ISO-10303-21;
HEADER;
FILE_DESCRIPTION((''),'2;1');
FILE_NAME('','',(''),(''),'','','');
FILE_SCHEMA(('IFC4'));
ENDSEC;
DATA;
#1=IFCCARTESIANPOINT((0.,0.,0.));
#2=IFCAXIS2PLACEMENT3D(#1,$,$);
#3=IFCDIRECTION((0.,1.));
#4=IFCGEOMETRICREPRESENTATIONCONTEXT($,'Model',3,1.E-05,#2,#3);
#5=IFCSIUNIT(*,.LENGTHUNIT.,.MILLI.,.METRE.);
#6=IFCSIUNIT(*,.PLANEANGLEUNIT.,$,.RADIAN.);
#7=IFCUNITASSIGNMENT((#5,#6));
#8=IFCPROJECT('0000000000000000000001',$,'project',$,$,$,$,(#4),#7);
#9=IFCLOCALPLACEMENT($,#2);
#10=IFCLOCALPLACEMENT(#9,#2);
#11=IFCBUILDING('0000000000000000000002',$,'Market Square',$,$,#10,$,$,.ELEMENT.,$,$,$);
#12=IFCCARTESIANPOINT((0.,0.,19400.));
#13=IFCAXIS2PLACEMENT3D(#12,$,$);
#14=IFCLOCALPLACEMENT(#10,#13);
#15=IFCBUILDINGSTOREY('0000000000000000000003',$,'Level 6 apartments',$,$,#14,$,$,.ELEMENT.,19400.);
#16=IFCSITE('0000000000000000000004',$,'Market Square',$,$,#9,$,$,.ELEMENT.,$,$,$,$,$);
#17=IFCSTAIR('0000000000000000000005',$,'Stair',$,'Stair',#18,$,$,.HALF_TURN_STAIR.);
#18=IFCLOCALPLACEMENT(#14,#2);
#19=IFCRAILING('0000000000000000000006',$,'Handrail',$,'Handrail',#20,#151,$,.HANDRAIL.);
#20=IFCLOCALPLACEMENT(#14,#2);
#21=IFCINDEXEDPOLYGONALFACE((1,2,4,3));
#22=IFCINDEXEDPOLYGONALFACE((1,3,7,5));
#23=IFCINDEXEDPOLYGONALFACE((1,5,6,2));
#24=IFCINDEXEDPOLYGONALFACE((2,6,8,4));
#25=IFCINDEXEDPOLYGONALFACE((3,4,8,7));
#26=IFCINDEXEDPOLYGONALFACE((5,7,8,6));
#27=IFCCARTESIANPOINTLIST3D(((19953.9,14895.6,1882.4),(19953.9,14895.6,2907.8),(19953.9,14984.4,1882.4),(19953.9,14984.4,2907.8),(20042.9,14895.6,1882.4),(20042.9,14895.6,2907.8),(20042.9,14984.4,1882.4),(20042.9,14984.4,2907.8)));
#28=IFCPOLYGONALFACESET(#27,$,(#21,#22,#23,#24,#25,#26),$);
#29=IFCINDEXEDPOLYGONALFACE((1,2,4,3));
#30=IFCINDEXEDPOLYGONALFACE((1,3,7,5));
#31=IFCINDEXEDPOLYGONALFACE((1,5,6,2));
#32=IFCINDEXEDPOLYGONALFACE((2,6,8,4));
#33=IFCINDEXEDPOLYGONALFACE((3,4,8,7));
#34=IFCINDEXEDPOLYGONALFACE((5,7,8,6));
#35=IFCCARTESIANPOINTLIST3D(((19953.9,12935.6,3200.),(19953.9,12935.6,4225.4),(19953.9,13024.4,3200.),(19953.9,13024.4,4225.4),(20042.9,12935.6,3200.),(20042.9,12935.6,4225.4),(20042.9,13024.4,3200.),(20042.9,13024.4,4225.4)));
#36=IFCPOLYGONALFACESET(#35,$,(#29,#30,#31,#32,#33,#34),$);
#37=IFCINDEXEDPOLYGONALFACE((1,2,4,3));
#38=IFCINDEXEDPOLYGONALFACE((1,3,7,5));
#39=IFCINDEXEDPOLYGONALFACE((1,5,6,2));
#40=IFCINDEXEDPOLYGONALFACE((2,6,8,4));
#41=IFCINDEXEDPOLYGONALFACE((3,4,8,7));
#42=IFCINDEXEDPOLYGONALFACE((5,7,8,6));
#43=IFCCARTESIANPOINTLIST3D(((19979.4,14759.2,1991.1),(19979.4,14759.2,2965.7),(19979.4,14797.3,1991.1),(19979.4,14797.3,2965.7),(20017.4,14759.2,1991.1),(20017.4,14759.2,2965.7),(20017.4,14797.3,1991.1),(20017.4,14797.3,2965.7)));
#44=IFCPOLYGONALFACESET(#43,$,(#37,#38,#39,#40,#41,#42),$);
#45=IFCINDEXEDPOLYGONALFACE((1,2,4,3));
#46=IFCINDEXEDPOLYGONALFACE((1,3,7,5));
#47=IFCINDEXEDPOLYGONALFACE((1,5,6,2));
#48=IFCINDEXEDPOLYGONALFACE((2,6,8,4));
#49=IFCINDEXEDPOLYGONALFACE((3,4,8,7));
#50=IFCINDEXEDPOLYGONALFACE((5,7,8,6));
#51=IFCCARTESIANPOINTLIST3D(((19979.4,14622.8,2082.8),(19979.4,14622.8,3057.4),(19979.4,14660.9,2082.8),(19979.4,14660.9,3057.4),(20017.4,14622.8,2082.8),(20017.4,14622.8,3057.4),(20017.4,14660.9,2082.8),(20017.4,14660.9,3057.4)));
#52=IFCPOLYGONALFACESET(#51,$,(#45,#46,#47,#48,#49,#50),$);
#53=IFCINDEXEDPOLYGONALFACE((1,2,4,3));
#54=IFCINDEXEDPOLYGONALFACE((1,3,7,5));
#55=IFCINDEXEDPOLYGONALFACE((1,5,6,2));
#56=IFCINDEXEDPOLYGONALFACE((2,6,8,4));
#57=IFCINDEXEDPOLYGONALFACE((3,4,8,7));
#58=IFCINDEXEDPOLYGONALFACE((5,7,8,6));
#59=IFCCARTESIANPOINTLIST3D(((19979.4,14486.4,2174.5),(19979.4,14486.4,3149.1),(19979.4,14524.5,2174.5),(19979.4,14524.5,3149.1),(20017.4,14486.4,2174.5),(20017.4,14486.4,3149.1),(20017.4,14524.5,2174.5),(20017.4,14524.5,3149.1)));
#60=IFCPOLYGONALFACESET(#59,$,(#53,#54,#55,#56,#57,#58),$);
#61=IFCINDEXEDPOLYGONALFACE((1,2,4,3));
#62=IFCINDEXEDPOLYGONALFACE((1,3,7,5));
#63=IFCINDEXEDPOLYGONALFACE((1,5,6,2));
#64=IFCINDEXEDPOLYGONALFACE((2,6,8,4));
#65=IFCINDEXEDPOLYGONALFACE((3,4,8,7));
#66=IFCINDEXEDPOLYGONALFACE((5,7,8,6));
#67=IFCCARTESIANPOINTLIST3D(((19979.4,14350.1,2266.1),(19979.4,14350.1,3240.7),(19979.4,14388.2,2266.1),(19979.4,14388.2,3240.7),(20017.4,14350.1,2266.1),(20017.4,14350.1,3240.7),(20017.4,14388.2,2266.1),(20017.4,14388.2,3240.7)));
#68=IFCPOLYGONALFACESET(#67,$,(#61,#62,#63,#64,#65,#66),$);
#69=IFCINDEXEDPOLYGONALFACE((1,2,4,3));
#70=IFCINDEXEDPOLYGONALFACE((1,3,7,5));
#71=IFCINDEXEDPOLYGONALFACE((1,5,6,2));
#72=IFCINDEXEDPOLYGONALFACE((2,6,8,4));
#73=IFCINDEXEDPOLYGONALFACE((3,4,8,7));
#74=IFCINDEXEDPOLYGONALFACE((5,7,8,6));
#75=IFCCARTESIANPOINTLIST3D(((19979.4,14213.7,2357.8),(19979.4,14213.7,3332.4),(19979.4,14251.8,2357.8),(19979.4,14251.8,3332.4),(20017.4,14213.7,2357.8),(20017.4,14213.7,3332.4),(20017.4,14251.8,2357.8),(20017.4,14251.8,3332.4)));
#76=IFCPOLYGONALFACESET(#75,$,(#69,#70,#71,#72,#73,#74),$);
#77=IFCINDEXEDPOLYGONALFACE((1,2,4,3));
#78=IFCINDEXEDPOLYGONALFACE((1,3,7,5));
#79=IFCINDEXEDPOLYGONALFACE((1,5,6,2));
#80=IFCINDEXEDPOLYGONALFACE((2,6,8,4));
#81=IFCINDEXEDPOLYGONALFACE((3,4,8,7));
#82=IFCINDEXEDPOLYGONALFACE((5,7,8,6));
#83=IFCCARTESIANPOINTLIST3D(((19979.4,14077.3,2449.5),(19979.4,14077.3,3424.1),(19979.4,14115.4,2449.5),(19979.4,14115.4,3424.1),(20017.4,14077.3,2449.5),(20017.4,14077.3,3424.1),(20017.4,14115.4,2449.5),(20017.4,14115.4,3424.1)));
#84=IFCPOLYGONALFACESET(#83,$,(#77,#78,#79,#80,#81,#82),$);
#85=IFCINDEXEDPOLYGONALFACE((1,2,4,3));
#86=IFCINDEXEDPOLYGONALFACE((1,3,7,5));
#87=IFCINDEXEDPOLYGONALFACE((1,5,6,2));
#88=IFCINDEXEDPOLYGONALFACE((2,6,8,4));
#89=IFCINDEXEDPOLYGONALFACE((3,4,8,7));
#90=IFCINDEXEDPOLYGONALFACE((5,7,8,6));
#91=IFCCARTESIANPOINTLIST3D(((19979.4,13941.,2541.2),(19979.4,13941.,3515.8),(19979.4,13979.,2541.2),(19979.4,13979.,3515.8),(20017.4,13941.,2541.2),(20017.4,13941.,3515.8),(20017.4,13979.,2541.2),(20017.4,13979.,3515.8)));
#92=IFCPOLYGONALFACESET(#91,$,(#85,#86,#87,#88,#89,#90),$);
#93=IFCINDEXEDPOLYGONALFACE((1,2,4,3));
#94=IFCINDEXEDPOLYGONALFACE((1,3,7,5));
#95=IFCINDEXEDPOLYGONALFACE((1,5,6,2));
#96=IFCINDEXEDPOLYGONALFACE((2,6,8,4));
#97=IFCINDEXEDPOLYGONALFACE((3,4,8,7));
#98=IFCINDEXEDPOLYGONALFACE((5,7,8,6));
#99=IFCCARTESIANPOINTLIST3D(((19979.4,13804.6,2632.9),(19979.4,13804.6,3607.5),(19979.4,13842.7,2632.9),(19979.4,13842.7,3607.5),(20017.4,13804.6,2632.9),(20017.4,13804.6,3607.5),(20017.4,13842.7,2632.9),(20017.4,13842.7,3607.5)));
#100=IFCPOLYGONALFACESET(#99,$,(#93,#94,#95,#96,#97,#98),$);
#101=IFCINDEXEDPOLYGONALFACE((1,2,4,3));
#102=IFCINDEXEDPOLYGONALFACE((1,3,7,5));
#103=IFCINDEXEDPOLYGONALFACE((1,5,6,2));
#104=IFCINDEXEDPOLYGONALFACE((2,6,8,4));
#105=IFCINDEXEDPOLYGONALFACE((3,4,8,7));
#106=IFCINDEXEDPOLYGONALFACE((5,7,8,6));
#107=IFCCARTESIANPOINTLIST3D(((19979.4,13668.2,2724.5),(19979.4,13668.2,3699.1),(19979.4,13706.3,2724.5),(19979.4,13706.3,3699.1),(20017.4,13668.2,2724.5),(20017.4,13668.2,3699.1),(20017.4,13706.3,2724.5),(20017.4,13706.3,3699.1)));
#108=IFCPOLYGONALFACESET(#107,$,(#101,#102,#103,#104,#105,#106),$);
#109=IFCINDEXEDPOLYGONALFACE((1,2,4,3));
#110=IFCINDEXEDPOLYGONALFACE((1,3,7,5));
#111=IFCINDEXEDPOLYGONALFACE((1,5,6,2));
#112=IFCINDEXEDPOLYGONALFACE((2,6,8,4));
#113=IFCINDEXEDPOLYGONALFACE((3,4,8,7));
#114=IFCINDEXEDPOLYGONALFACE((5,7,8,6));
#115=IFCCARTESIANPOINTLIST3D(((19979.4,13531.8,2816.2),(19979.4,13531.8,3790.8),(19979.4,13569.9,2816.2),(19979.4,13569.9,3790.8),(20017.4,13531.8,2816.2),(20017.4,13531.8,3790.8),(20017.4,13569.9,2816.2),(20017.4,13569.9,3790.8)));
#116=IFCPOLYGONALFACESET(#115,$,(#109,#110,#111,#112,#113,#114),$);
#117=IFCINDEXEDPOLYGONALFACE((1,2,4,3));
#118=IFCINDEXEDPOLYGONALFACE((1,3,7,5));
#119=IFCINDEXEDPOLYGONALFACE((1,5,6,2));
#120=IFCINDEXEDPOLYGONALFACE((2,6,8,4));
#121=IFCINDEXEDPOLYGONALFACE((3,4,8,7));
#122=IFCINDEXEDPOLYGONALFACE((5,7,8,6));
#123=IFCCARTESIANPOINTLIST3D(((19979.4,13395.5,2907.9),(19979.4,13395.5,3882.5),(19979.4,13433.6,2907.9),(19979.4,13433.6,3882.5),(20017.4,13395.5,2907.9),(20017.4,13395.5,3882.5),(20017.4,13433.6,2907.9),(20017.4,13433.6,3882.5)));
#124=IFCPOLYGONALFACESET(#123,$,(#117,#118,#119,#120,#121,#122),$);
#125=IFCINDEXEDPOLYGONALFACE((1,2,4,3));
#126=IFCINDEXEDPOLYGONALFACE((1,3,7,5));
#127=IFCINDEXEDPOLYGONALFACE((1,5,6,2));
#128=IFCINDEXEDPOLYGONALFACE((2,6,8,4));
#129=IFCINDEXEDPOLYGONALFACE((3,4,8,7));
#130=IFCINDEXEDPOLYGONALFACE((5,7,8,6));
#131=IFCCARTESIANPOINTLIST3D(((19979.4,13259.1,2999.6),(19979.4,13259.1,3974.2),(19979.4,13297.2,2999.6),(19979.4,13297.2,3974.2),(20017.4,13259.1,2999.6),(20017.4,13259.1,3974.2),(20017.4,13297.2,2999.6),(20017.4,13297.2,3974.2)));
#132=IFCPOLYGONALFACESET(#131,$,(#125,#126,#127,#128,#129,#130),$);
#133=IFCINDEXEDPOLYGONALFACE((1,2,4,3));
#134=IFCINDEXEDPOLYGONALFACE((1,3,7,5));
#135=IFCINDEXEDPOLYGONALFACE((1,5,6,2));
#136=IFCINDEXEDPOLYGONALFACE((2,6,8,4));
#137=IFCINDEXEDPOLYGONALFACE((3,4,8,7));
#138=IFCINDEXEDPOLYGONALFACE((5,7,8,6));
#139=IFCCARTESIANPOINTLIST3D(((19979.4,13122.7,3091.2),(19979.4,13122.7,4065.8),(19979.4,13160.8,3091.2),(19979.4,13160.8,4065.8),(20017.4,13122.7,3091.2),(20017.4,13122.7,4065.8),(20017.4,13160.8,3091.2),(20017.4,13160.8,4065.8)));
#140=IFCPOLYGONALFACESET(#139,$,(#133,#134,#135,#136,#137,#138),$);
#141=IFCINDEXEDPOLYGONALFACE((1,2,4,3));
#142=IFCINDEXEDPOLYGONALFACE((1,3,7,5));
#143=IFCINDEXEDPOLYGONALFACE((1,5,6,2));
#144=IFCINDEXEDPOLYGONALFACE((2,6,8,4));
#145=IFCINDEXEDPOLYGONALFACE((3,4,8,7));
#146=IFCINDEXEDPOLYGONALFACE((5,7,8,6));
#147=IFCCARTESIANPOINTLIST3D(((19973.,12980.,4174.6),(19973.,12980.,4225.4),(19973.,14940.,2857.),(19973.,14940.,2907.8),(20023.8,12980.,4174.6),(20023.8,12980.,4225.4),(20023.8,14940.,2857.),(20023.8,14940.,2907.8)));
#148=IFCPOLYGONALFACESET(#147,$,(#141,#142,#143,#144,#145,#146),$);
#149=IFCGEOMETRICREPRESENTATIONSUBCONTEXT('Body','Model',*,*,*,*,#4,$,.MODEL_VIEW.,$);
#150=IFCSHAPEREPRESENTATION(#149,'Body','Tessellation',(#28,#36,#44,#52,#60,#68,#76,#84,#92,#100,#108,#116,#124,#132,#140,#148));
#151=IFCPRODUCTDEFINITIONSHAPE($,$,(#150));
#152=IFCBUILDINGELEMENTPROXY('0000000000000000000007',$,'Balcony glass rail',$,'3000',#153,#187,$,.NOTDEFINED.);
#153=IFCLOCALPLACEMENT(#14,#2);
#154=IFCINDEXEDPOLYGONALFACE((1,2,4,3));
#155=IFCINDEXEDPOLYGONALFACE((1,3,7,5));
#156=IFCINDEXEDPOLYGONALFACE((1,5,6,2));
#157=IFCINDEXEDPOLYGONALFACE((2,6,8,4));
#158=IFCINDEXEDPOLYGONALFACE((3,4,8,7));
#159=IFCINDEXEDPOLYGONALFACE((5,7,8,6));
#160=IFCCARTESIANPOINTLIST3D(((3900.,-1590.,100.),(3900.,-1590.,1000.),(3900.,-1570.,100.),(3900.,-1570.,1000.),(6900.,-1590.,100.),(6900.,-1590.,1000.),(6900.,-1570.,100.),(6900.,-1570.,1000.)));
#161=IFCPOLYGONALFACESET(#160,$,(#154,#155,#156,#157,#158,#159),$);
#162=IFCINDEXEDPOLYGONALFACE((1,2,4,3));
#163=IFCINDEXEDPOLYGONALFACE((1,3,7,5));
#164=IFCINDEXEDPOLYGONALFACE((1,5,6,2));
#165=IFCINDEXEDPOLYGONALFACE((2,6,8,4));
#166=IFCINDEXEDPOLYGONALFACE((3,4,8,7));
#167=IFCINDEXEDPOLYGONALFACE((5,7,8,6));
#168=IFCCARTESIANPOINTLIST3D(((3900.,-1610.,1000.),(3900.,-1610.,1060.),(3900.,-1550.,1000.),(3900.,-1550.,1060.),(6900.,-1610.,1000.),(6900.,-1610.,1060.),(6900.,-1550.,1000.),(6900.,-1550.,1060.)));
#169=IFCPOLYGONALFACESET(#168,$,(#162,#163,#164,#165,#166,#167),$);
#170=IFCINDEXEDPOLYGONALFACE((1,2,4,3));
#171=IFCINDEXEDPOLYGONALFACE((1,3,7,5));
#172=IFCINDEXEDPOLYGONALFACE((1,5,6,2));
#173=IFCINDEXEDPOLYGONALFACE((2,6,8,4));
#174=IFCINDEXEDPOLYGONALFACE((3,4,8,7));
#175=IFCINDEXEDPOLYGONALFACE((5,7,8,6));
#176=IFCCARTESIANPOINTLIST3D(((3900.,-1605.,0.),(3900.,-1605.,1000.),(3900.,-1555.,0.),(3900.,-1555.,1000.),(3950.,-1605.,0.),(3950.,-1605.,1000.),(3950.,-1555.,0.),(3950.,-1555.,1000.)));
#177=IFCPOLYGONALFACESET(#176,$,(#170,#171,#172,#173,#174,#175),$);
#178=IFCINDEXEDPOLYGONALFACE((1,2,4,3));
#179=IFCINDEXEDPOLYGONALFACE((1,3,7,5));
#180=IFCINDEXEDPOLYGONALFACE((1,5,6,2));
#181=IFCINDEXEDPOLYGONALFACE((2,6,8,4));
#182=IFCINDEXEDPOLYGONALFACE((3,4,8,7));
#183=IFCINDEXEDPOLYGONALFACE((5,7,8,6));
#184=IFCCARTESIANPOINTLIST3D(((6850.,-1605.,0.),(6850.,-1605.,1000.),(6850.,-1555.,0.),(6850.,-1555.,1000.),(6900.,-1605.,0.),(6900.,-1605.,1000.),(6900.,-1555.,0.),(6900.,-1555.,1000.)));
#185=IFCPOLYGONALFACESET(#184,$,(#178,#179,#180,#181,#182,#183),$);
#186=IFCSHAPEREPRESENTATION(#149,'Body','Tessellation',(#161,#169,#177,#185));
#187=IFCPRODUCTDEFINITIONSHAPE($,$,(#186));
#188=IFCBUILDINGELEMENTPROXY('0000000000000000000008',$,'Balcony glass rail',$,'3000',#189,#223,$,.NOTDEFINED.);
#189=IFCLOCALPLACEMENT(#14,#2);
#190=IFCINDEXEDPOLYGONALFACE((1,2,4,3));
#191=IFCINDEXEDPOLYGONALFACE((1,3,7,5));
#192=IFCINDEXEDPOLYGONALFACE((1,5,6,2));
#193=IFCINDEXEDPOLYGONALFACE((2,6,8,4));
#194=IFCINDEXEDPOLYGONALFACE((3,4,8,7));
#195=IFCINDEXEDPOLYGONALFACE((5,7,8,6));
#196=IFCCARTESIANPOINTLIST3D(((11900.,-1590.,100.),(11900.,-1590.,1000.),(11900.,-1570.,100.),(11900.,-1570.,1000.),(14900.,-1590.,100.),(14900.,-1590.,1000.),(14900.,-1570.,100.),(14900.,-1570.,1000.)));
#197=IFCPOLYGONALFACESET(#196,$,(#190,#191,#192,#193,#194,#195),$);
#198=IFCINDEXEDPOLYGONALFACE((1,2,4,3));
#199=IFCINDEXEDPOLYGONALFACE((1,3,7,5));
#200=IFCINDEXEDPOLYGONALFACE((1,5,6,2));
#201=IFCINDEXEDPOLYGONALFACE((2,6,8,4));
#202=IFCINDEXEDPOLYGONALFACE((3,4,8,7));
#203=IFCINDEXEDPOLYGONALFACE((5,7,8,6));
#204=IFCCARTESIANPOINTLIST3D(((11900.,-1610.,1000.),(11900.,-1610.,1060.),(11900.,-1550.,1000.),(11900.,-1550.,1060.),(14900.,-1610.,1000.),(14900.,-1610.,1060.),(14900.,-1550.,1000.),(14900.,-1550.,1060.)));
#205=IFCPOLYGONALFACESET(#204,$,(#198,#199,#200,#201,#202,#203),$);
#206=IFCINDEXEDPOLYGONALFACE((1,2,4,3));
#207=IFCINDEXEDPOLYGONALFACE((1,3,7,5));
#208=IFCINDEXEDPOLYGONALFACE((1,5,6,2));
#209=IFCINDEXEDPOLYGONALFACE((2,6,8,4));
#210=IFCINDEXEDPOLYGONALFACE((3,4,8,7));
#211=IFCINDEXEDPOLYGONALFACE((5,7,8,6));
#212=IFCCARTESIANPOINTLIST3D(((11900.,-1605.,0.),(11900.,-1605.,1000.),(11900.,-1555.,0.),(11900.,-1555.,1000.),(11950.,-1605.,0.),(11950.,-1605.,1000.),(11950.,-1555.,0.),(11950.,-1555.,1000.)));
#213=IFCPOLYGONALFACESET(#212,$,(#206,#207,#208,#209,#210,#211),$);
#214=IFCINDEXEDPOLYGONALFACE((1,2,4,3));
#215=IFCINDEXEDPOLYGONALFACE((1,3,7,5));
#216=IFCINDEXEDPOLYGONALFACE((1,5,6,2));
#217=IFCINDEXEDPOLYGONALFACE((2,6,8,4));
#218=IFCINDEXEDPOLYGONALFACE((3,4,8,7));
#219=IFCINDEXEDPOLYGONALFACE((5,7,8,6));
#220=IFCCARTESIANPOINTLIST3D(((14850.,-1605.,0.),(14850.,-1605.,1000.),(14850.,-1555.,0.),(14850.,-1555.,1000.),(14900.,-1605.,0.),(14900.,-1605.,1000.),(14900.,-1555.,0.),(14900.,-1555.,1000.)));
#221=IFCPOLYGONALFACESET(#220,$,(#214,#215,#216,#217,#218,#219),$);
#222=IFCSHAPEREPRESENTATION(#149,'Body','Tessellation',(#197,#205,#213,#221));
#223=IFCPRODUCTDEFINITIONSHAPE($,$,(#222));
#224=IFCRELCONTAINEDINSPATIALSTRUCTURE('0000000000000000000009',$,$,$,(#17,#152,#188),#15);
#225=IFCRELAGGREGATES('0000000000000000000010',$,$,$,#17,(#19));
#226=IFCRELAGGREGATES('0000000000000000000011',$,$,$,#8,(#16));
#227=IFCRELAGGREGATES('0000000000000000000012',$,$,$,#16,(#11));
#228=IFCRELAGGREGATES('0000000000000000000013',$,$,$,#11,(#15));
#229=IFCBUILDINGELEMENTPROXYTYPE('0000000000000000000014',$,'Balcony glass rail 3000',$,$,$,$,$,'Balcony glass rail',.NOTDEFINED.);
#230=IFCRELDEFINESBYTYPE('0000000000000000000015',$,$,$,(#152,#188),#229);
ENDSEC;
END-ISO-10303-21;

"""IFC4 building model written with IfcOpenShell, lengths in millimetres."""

from ifc_helpers import new_model, si_unit, direction, frame, origin, origin_with_axes, place, context, subcontext, project, spatial, polyline, outline, extrude, source, transform, mapped, type_object, type_shapes, element, aggregate, save


model = new_model("IFC4")

# Units and contexts
model_context = context("Model", 3, precision=1e-05, world=origin(), true_north=direction((0.0, 1.0)))
body_context = subcontext(model_context, "Body", "Model", "MODEL_VIEW")
ifc_project = project(units=[si_unit("LENGTHUNIT", "METRE", prefix="MILLI"), si_unit("PLANEANGLEUNIT", "RADIAN")], contexts=[model_context])

# Site, building, storey
site_placement = place(None, origin())
site = spatial("IfcSite", under=ifc_project, at=site_placement, Name="Market Square", CompositionType="ELEMENT")
building_placement = place(site_placement, origin())
building = spatial("IfcBuilding", under=site, at=building_placement, Name="Market Square", CompositionType="ELEMENT")
storey_placement = place(building_placement, frame((0.0, 0.0, 19400.0)))
storey = spatial("IfcBuildingStorey", under=building, at=storey_placement, Name="Level 6 apartments", CompositionType="ELEMENT", Elevation=19400.0)

# Stair
stair_placement = place(storey_placement, origin_with_axes())
stair = element("IfcStair", 1, at=stair_placement, inside=storey, Name="Stair", ObjectType="Stair", PredefinedType="HALF_TURN_STAIR")

# Railing
railing_1_placement = place(storey_placement, origin_with_axes())
railing_1 = element("IfcRailing", 2, at=railing_1_placement, Name="Handrail", ObjectType="Handrail", PredefinedType="HANDRAIL", context=body_context, shape_type="SweptSolid", body=[
    extrude(outline(polyline([(-44.5, -44.5), (44.5, -44.5), (44.5, 44.5), (-44.5, 44.5), (-44.5, -44.5)])), frame((19998.4, 14940.0, 1882.4), z_axis=(0.0, 0.0, 1.0), x_axis=(1.0, 0.0, 0.0)), (0.0, 0.0, 1.0), 1025.4),
    extrude(outline(polyline([(-44.5, -44.5), (44.5, -44.5), (44.5, 44.5), (-44.5, 44.5), (-44.5, -44.5)])), frame((19998.4, 12980.0, 3200.0), z_axis=(0.0, 0.0, 1.0), x_axis=(1.0, 0.0, 0.0)), (0.0, 0.0, 1.0), 1025.4),
    extrude(outline(polyline([(-19.1, -19.1), (19.1, -19.1), (19.1, 19.1), (-19.1, 19.1), (-19.1, -19.1)])), frame((19998.4, 14778.2, 1991.1), z_axis=(0.0, 0.0, 1.0), x_axis=(1.0, 0.0, 0.0)), (0.0, 0.0, 1.0), 974.6),
    extrude(outline(polyline([(-19.1, -19.1), (19.1, -19.1), (19.1, 19.1), (-19.1, 19.1), (-19.1, -19.1)])), frame((19998.4, 14641.9, 2082.8), z_axis=(0.0, 0.0, 1.0), x_axis=(1.0, 0.0, 0.0)), (0.0, 0.0, 1.0), 974.6),
    extrude(outline(polyline([(-19.1, -19.1), (19.1, -19.1), (19.1, 19.1), (-19.1, 19.1), (-19.1, -19.1)])), frame((19998.4, 14505.5, 2174.5), z_axis=(0.0, 0.0, 1.0), x_axis=(1.0, 0.0, 0.0)), (0.0, 0.0, 1.0), 974.6),
    extrude(outline(polyline([(-19.1, -19.1), (19.1, -19.1), (19.1, 19.1), (-19.1, 19.1), (-19.1, -19.1)])), frame((19998.4, 14369.1, 2266.1), z_axis=(0.0, 0.0, 1.0), x_axis=(1.0, 0.0, 0.0)), (0.0, 0.0, 1.0), 974.6),
    extrude(outline(polyline([(-19.1, -19.1), (19.1, -19.1), (19.1, 19.1), (-19.1, 19.1), (-19.1, -19.1)])), frame((19998.4, 14232.7, 2357.8), z_axis=(0.0, 0.0, 1.0), x_axis=(1.0, 0.0, 0.0)), (0.0, 0.0, 1.0), 974.6),
    extrude(outline(polyline([(-19.1, -19.1), (19.1, -19.1), (19.1, 19.1), (-19.1, 19.1), (-19.1, -19.1)])), frame((19998.4, 14096.4, 2449.5), z_axis=(0.0, 0.0, 1.0), x_axis=(1.0, 0.0, 0.0)), (0.0, 0.0, 1.0), 974.6),
    extrude(outline(polyline([(-19.1, -19.1), (19.1, -19.1), (19.1, 19.1), (-19.1, 19.1), (-19.1, -19.1)])), frame((19998.4, 13960.0, 2541.2), z_axis=(0.0, 0.0, 1.0), x_axis=(1.0, 0.0, 0.0)), (0.0, 0.0, 1.0), 974.6),
    extrude(outline(polyline([(-19.1, -19.1), (19.1, -19.1), (19.1, 19.1), (-19.1, 19.1), (-19.1, -19.1)])), frame((19998.4, 13823.6, 2632.9), z_axis=(0.0, 0.0, 1.0), x_axis=(1.0, 0.0, 0.0)), (0.0, 0.0, 1.0), 974.6),
    extrude(outline(polyline([(-19.1, -19.1), (19.1, -19.1), (19.1, 19.1), (-19.1, 19.1), (-19.1, -19.1)])), frame((19998.4, 13687.3, 2724.5), z_axis=(0.0, 0.0, 1.0), x_axis=(1.0, 0.0, 0.0)), (0.0, 0.0, 1.0), 974.6),
    extrude(outline(polyline([(-19.1, -19.1), (19.1, -19.1), (19.1, 19.1), (-19.1, 19.1), (-19.1, -19.1)])), frame((19998.4, 13550.9, 2816.2), z_axis=(0.0, 0.0, 1.0), x_axis=(1.0, 0.0, 0.0)), (0.0, 0.0, 1.0), 974.6),
    extrude(outline(polyline([(-19.1, -19.1), (19.1, -19.1), (19.1, 19.1), (-19.1, 19.1), (-19.1, -19.1)])), frame((19998.4, 13414.5, 2907.9), z_axis=(0.0, 0.0, 1.0), x_axis=(1.0, 0.0, 0.0)), (0.0, 0.0, 1.0), 974.6),
    extrude(outline(polyline([(-19.1, -19.1), (19.1, -19.1), (19.1, 19.1), (-19.1, 19.1), (-19.1, -19.1)])), frame((19998.4, 13278.1, 2999.6), z_axis=(0.0, 0.0, 1.0), x_axis=(1.0, 0.0, 0.0)), (0.0, 0.0, 1.0), 974.6),
    extrude(outline(polyline([(-19.1, -19.1), (19.1, -19.1), (19.1, 19.1), (-19.1, 19.1), (-19.1, -19.1)])), frame((19998.4, 13141.8, 3091.2), z_axis=(0.0, 0.0, 1.0), x_axis=(1.0, 0.0, 0.0)), (0.0, 0.0, 1.0), 974.6),
    extrude(outline(polyline([(0.0, 0.0), (50.8, 0.0), (50.8, 50.8), (0.0, 50.8), (0.0, 0.0)])), frame((19973.0, 14940.0, 2857.0), z_axis=(0.0, -1.0, 0.0), x_axis=(1.0, 0.0, 0.0)), (0.0, 0.557915, 0.829898), 2361.7),
])
aggregate(stair, [railing_1])

# Building element proxies
building_element_proxy_type = type_object("IfcBuildingElementProxyType", Name="Balcony glass rail 3000", ElementType="Balcony glass rail", PredefinedType="NOTDEFINED")
shared_shape = source(origin(), body_context, "Body", "SweptSolid", [
    extrude(outline(polyline([(0.0, -10.0), (3000.0, -10.0), (3000.0, 10.0), (0.0, 10.0), (0.0, -10.0)])), frame((0.0, 0.0, 100.0)), (0.0, 0.0, 1.0), 900.0),
    extrude(outline(polyline([(0.0, -30.0), (3000.0, -30.0), (3000.0, 30.0), (0.0, 30.0), (0.0, -30.0)])), frame((0.0, 0.0, 1000.0)), (0.0, 0.0, 1.0), 60.0),
    extrude(outline(polyline([(0.0, -25.0), (50.0, -25.0), (50.0, 25.0), (0.0, 25.0), (0.0, -25.0)])), origin(), (0.0, 0.0, 1.0), 1000.0),
    extrude(outline(polyline([(2950.0, -25.0), (3000.0, -25.0), (3000.0, 25.0), (2950.0, 25.0), (2950.0, -25.0)])), origin(), (0.0, 0.0, 1.0), 1000.0),
])
type_shapes(building_element_proxy_type, [shared_shape])
for number, where, z_axis, x_axis, name in (
    (3, (3900.0, -1580.0, 0.0), (0.0, 0.0, 1.0), (1.0, 0.0, 0.0), "Balcony glass rail"),
    (4, (11900.0, -1580.0, 0.0), (0.0, 0.0, 1.0), (1.0, 0.0, 0.0), "Balcony glass rail"),
):
    element("IfcBuildingElementProxy", number, at=place(storey_placement, frame(where, z_axis=z_axis, x_axis=x_axis)), inside=storey, type_object=building_element_proxy_type, Name=name, ObjectType="3000", PredefinedType="NOTDEFINED", context=body_context, shape_type="MappedRepresentation", body=[
        mapped(shared_shape, transform((0.0, 0.0, 0.0))),
    ])

save(model, "model.ifc")
